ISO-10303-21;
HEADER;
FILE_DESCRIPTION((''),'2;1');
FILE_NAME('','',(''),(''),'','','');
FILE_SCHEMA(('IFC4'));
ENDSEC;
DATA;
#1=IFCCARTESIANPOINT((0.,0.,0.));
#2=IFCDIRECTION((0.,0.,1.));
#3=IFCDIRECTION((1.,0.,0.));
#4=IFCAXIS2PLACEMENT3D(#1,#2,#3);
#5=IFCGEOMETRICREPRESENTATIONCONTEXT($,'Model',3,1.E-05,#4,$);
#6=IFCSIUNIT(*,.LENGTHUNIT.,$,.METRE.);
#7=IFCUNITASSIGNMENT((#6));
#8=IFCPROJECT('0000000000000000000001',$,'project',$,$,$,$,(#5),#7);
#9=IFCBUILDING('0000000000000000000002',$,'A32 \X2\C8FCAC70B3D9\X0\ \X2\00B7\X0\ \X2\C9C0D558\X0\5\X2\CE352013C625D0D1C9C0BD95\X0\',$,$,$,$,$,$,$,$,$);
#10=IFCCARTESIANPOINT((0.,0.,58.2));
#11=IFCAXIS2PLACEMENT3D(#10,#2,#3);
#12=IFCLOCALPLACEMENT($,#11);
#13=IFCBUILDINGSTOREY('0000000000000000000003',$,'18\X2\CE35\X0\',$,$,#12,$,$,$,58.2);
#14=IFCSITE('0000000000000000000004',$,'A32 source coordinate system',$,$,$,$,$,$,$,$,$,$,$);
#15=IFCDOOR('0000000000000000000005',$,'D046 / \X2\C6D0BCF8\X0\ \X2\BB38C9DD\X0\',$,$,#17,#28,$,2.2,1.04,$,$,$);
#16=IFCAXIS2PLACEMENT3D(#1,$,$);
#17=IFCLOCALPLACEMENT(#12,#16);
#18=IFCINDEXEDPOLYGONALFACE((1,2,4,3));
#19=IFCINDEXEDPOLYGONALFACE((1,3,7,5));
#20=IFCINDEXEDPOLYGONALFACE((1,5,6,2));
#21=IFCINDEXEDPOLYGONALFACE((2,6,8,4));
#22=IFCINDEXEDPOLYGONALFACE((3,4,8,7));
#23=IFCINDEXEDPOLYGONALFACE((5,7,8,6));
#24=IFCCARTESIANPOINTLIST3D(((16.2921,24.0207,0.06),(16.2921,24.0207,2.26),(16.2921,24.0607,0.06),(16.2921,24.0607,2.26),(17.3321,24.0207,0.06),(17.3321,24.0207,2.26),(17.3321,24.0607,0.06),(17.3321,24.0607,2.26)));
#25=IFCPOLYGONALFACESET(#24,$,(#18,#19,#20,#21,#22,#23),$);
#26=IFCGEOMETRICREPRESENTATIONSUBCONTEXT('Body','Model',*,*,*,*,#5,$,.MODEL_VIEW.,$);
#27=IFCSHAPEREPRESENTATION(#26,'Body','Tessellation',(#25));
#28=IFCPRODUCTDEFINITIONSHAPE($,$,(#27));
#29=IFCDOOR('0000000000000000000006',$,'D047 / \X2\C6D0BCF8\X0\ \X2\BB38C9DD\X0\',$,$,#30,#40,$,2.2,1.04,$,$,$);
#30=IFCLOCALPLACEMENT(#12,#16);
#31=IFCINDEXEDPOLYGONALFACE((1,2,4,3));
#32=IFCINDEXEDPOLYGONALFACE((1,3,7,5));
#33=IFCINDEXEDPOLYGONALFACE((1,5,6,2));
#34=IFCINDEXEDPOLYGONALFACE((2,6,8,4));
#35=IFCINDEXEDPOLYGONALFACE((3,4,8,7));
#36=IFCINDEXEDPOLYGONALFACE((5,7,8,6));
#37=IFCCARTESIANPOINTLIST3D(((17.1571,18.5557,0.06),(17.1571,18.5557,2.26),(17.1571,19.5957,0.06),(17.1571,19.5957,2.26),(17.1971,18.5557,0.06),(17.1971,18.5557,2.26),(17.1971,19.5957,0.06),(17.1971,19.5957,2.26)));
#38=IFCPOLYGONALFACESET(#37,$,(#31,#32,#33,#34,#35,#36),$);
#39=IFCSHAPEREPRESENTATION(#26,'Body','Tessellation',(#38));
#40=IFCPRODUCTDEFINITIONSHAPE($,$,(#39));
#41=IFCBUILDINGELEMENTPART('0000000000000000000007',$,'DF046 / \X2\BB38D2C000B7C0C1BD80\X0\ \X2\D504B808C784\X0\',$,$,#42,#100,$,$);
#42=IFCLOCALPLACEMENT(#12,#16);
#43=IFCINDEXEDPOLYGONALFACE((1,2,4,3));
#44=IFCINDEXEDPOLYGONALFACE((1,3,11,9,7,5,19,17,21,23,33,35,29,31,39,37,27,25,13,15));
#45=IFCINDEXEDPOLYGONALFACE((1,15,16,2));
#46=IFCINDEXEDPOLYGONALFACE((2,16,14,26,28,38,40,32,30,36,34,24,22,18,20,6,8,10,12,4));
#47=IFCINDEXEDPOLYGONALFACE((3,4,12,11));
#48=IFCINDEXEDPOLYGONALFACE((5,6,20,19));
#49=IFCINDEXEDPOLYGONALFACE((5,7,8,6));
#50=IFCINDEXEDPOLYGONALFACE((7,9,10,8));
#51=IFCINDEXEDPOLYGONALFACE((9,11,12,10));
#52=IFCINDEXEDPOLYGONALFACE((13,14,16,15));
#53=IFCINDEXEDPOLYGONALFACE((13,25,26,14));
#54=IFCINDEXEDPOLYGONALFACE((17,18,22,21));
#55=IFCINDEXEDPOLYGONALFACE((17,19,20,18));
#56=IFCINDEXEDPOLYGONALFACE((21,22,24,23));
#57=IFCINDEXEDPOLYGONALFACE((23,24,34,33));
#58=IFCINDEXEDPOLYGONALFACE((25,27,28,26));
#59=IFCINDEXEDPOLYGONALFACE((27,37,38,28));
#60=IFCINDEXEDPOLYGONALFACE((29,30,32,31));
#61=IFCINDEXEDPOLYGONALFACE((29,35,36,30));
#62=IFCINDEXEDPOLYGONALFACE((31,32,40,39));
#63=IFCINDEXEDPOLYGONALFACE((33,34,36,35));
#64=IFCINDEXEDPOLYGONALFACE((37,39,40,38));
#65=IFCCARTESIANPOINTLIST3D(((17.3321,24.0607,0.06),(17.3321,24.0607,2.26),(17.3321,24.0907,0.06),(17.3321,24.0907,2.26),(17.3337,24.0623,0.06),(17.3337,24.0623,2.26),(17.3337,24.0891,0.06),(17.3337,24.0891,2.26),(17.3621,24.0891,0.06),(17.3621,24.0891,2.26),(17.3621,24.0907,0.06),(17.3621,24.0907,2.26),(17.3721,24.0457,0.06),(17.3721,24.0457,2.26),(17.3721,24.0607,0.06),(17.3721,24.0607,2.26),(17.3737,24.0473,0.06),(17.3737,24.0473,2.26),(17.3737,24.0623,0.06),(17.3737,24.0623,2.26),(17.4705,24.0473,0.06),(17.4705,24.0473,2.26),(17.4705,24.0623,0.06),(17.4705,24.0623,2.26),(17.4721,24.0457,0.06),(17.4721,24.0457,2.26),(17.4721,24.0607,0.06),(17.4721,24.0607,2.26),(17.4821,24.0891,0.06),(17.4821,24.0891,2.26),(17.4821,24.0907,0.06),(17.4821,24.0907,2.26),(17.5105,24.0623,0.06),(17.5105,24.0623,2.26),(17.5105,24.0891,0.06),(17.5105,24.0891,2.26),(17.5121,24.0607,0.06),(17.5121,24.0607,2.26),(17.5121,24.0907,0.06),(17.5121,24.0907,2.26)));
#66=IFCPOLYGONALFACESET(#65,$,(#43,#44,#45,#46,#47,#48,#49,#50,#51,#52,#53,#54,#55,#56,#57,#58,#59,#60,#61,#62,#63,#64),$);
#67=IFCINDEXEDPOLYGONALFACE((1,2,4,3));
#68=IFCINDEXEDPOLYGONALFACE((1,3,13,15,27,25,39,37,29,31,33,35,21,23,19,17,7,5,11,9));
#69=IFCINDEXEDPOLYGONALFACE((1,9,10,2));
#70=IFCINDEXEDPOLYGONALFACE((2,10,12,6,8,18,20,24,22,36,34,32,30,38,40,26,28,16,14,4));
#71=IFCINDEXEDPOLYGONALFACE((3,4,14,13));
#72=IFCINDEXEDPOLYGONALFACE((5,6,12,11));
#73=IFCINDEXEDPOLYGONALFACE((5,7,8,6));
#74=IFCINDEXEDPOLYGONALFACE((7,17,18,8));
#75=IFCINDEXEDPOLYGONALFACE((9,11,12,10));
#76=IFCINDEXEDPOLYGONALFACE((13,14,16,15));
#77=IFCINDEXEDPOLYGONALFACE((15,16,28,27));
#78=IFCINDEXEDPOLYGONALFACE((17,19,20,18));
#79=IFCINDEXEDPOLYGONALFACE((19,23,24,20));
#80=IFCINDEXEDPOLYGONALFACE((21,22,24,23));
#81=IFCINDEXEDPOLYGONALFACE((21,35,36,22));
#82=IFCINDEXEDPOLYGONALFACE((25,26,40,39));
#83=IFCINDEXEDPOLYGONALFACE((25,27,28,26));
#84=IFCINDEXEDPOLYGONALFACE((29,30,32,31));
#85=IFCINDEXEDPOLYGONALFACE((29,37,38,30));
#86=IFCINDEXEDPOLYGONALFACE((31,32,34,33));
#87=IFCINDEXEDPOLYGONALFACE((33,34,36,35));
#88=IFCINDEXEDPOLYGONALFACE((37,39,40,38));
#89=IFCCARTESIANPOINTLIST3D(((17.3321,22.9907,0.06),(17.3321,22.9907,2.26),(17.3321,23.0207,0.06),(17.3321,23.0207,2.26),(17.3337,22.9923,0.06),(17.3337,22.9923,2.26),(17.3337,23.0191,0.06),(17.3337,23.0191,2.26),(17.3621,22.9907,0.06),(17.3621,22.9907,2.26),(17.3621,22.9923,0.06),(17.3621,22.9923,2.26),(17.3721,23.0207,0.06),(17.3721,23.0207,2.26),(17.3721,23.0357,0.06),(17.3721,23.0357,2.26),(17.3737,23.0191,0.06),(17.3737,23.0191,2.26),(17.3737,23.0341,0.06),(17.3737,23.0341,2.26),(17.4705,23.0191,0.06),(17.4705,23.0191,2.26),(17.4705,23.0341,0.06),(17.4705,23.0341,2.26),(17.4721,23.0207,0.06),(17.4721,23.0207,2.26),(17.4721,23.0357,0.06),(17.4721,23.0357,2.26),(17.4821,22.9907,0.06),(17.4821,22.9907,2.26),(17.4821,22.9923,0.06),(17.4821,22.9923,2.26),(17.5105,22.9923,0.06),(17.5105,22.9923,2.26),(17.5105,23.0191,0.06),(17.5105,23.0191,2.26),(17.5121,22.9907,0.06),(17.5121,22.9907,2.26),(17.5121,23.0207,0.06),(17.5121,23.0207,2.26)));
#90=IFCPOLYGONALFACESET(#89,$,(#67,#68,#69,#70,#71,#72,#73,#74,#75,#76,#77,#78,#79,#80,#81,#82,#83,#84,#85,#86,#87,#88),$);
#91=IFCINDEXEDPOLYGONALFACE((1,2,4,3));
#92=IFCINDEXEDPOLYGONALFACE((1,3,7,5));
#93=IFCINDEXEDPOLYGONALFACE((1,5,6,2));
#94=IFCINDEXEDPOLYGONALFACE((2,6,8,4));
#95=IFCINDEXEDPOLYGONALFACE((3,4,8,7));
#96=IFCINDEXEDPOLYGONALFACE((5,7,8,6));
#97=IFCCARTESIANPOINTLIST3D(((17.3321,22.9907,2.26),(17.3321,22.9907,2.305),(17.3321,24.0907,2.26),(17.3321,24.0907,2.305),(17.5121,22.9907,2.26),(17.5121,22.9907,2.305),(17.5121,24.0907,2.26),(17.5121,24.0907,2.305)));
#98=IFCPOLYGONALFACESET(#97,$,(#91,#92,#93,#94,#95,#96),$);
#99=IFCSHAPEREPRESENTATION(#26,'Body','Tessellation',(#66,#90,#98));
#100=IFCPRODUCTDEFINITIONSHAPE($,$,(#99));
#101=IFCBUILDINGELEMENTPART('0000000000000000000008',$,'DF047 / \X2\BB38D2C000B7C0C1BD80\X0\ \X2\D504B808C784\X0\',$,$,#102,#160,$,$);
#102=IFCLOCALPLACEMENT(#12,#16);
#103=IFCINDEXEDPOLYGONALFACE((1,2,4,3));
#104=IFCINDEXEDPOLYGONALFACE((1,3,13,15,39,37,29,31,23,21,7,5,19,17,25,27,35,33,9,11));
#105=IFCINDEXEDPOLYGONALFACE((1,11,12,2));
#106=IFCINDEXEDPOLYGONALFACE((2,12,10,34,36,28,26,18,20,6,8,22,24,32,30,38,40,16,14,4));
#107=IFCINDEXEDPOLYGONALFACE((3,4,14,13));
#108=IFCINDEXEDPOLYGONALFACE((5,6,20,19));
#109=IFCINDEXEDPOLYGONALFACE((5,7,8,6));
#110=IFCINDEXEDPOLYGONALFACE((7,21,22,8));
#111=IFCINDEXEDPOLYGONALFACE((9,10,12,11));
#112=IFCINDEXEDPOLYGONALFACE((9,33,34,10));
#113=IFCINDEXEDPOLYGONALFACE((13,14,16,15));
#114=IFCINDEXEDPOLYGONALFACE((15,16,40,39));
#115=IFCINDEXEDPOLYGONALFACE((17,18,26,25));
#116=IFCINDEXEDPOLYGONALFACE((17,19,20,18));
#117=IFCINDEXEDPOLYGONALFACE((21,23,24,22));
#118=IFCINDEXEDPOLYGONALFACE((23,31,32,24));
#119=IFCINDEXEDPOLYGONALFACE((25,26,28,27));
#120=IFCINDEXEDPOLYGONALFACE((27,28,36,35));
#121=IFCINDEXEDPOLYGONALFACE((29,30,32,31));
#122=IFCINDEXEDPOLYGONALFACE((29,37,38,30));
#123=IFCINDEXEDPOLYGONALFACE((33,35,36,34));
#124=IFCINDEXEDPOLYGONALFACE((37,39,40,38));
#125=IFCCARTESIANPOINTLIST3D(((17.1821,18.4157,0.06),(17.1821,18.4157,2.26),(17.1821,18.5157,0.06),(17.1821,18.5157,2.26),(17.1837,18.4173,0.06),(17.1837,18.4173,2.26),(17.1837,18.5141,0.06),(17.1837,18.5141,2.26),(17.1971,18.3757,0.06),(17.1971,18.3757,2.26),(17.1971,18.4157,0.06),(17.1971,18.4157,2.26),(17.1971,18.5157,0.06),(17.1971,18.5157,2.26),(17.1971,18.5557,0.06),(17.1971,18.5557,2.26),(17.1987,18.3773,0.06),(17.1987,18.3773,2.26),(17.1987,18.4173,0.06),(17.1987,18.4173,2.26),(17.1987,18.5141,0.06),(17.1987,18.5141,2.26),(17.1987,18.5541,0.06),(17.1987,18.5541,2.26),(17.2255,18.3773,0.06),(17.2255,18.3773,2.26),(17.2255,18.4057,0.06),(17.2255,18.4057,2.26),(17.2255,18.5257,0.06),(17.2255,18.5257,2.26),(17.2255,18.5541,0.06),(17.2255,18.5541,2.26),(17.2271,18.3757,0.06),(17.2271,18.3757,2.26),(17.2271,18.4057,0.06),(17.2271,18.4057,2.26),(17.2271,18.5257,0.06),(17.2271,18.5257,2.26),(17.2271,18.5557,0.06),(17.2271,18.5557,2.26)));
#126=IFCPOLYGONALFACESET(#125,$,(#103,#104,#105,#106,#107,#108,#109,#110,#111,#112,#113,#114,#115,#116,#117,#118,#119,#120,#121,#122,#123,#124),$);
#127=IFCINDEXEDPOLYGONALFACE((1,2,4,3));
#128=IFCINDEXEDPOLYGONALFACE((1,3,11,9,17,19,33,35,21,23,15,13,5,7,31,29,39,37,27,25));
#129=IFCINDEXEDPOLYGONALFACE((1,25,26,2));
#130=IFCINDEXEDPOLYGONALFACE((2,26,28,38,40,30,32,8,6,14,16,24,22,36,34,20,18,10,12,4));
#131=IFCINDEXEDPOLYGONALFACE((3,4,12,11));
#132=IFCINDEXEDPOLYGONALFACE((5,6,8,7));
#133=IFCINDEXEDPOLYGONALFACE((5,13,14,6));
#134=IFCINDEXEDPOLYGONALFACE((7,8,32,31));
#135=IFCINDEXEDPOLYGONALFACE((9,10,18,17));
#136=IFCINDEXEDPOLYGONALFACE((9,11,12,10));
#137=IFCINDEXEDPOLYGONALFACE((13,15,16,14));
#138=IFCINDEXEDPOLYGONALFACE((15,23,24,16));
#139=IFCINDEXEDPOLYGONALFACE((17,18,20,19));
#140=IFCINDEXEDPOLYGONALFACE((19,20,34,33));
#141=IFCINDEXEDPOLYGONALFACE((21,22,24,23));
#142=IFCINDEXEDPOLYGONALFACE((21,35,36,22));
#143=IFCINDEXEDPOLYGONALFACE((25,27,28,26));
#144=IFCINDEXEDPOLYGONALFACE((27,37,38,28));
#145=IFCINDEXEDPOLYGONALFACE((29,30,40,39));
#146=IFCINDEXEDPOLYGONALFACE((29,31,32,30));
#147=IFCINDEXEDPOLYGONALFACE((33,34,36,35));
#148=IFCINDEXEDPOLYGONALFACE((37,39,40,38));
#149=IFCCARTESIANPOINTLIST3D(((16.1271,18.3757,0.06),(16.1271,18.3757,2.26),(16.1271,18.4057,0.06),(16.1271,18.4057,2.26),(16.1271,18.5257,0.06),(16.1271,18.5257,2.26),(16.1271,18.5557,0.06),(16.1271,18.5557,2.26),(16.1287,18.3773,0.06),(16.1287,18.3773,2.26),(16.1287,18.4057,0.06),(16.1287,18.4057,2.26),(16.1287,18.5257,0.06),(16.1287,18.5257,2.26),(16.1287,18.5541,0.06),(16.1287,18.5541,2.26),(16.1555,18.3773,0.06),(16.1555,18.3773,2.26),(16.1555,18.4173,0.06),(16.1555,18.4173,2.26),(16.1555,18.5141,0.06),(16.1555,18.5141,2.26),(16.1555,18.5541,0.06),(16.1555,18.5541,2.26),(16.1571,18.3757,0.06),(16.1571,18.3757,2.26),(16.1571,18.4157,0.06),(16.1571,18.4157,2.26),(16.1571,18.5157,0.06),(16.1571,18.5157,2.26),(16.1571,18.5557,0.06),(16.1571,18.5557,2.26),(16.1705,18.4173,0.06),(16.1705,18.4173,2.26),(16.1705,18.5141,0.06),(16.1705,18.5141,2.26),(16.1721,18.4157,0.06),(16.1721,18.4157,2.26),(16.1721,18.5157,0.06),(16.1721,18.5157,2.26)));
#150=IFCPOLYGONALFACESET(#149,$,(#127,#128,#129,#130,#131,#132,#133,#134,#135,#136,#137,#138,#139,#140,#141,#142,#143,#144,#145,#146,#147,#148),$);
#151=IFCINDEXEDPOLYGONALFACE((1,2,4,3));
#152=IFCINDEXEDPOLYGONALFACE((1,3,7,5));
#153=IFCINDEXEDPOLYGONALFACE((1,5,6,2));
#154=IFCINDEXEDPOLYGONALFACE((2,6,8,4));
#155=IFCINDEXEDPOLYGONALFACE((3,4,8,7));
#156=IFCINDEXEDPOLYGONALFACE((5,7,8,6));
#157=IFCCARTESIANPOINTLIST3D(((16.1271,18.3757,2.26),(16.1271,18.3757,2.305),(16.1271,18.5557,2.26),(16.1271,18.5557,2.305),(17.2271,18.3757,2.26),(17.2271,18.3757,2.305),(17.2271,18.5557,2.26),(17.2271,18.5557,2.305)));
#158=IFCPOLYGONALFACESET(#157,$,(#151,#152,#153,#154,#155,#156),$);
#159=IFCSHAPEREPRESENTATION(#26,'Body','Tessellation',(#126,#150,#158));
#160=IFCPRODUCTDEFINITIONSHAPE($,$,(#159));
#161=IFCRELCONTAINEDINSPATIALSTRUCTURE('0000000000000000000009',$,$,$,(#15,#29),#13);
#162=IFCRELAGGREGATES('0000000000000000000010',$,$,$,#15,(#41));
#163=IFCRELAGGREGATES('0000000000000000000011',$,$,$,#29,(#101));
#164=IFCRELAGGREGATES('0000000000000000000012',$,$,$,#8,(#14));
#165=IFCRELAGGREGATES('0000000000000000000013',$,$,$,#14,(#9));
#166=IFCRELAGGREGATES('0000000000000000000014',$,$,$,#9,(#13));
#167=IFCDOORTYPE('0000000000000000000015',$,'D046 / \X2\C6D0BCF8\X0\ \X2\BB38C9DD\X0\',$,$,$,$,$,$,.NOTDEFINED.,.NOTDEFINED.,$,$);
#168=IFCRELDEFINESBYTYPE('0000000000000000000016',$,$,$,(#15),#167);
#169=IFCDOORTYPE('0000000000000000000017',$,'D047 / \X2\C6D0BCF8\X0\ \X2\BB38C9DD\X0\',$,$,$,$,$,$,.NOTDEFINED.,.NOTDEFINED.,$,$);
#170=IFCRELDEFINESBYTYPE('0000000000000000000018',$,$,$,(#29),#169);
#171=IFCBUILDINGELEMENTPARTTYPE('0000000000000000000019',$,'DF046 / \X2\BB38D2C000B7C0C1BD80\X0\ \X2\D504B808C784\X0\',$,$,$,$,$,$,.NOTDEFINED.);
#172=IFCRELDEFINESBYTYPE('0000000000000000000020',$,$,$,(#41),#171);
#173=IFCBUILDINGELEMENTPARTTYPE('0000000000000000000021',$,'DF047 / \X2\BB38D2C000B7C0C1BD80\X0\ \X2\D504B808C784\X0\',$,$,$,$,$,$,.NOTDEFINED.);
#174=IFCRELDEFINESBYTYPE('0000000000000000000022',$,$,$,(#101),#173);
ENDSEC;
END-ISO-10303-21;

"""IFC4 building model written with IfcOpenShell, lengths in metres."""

from ifc_helpers import new_model, si_unit, frame, origin, origin_with_axes, place, context, subcontext, project, spatial, polyline, outline, extrude, source, transform, mapped, type_object, type_shapes, element, aggregate, save


model = new_model("IFC4")

# Units and contexts
model_context = context("Model", 3, precision=1e-05, world=origin_with_axes())
body_context = subcontext(model_context, "Body", "Model", "MODEL_VIEW")
ifc_project = project(units=[si_unit("LENGTHUNIT", "METRE")], contexts=[model_context])

# Site, building, storey
storey_placement = place(None, frame((0.0, 0.0, 58.2), z_axis=(0.0, 0.0, 1.0), x_axis=(1.0, 0.0, 0.0)))
site = spatial("IfcSite", under=ifc_project, Name="A32 source coordinate system")
building = spatial("IfcBuilding", under=site, Name="A32 주거동 · 지하5층–옥탑지붕")
storey = spatial("IfcBuildingStorey", under=building, at=storey_placement, Name="18층", Elevation=58.2)

# Doors
door_type_1 = type_object("IfcDoorType", Name="D046 / 원본 문짝", OperationType="NOTDEFINED", PredefinedType="NOTDEFINED")
shared_shape_1 = source(origin(), body_context, "Body", "SweptSolid", [
    extrude(outline(polyline([(17.3321, 24.0607), (17.3321, 24.0207), (16.2921, 24.0207), (16.2921, 24.0607), (17.3321, 24.0607)])), frame((0.0, 0.0, 0.06)), (0.0, 0.0, 1.0), 2.2),
])
type_shapes(door_type_1, [shared_shape_1])
door_1_placement = place(storey_placement, origin_with_axes())
door_1 = element("IfcDoor", 1, at=door_1_placement, inside=storey, type_object=door_type_1, Name="D046 / 원본 문짝", OverallHeight=2.2, OverallWidth=1.04, context=body_context, shape_type="MappedRepresentation", body=[
    mapped(shared_shape_1, transform((0.0, 0.0, 0.0), scale=1.0)),
])
door_type_2 = type_object("IfcDoorType", Name="D047 / 원본 문짝", OperationType="NOTDEFINED", PredefinedType="NOTDEFINED")
shared_shape_2 = source(origin(), body_context, "Body", "SweptSolid", [
    extrude(outline(polyline([(17.1971, 18.5557), (17.1571, 18.5557), (17.1571, 19.5957), (17.1971, 19.5957), (17.1971, 18.5557)])), frame((0.0, 0.0, 0.06)), (0.0, 0.0, 1.0), 2.2),
])
type_shapes(door_type_2, [shared_shape_2])
door_2_placement = place(storey_placement, origin_with_axes())
door_2 = element("IfcDoor", 2, at=door_2_placement, inside=storey, type_object=door_type_2, Name="D047 / 원본 문짝", OverallHeight=2.2, OverallWidth=1.04, context=body_context, shape_type="MappedRepresentation", body=[
    mapped(shared_shape_2, transform((0.0, 0.0, 0.0), scale=1.0)),
])

# Building element parts
building_element_part_type_1 = type_object("IfcBuildingElementPartType", Name="DF046 / 문틀·상부 프레임", PredefinedType="NOTDEFINED")
shared_shape_3 = source(origin(), body_context, "Body", "SweptSolid", [
    extrude(outline(polyline([(17.3337, 24.0891), (17.3337, 24.0623), (17.3737, 24.0623), (17.3737, 24.0473), (17.4705, 24.0473), (17.4705, 24.0623), (17.5105, 24.0623), (17.5105, 24.0891), (17.4821, 24.0891), (17.4821, 24.0907), (17.5121, 24.0907), (17.5121, 24.0607), (17.4721, 24.0607), (17.4721, 24.0457), (17.3721, 24.0457), (17.3721, 24.0607), (17.3321, 24.0607), (17.3321, 24.0907), (17.3621, 24.0907), (17.3621, 24.0891), (17.3337, 24.0891)])), frame((0.0, 0.0, 0.06)), (0.0, 0.0, 1.0), 2.2),
    extrude(outline(polyline([(17.3621, 22.9907), (17.3321, 22.9907), (17.3321, 23.0207), (17.3721, 23.0207), (17.3721, 23.0357), (17.4721, 23.0357), (17.4721, 23.0207), (17.5121, 23.0207), (17.5121, 22.9907), (17.4821, 22.9907), (17.4821, 22.9923), (17.5105, 22.9923), (17.5105, 23.0191), (17.4705, 23.0191), (17.4705, 23.0341), (17.3737, 23.0341), (17.3737, 23.0191), (17.3337, 23.0191), (17.3337, 22.9923), (17.3621, 22.9923), (17.3621, 22.9907)])), frame((0.0, 0.0, 0.06)), (0.0, 0.0, 1.0), 2.2),
    extrude(outline(polyline([(17.3321, 22.9907), (17.3321, 24.0907), (17.5121, 24.0907), (17.5121, 22.9907), (17.3321, 22.9907)])), frame((0.0, 0.0, 2.26)), (0.0, 0.0, 1.0), 0.045),
])
type_shapes(building_element_part_type_1, [shared_shape_3])
building_element_part_1_placement = place(door_1_placement, origin_with_axes())
building_element_part_1 = element("IfcBuildingElementPart", 3, at=building_element_part_1_placement, type_object=building_element_part_type_1, Name="DF046 / 문틀·상부 프레임", context=body_context, shape_type="MappedRepresentation", body=[
    mapped(shared_shape_3, transform((0.0, 0.0, 0.0), scale=1.0)),
])
aggregate(door_1, [building_element_part_1])
building_element_part_type_2 = type_object("IfcBuildingElementPartType", Name="DF047 / 문틀·상부 프레임", PredefinedType="NOTDEFINED")
shared_shape_4 = source(origin(), body_context, "Body", "SweptSolid", [
    extrude(outline(polyline([(17.2255, 18.5541), (17.1987, 18.5541), (17.1987, 18.5141), (17.1837, 18.5141), (17.1837, 18.4173), (17.1987, 18.4173), (17.1987, 18.3773), (17.2255, 18.3773), (17.2255, 18.4057), (17.2271, 18.4057), (17.2271, 18.3757), (17.1971, 18.3757), (17.1971, 18.4157), (17.1821, 18.4157), (17.1821, 18.5157), (17.1971, 18.5157), (17.1971, 18.5557), (17.2271, 18.5557), (17.2271, 18.5257), (17.2255, 18.5257), (17.2255, 18.5541)])), frame((0.0, 0.0, 0.06)), (0.0, 0.0, 1.0), 2.2),
    extrude(outline(polyline([(16.1271, 18.5257), (16.1271, 18.5557), (16.1571, 18.5557), (16.1571, 18.5157), (16.1721, 18.5157), (16.1721, 18.4157), (16.1571, 18.4157), (16.1571, 18.3757), (16.1271, 18.3757), (16.1271, 18.4057), (16.1287, 18.4057), (16.1287, 18.3773), (16.1555, 18.3773), (16.1555, 18.4173), (16.1705, 18.4173), (16.1705, 18.5141), (16.1555, 18.5141), (16.1555, 18.5541), (16.1287, 18.5541), (16.1287, 18.5257), (16.1271, 18.5257)])), frame((0.0, 0.0, 0.06)), (0.0, 0.0, 1.0), 2.2),
    extrude(outline(polyline([(16.1271, 18.3757), (16.1271, 18.5557), (17.2271, 18.5557), (17.2271, 18.3757), (16.1271, 18.3757)])), frame((0.0, 0.0, 2.26)), (0.0, 0.0, 1.0), 0.045),
])
type_shapes(building_element_part_type_2, [shared_shape_4])
building_element_part_2_placement = place(door_2_placement, origin_with_axes())
building_element_part_2 = element("IfcBuildingElementPart", 4, at=building_element_part_2_placement, type_object=building_element_part_type_2, Name="DF047 / 문틀·상부 프레임", context=body_context, shape_type="MappedRepresentation", body=[
    mapped(shared_shape_4, transform((0.0, 0.0, 0.0), scale=1.0)),
])
aggregate(door_2, [building_element_part_2])

save(model, "model.ifc")
